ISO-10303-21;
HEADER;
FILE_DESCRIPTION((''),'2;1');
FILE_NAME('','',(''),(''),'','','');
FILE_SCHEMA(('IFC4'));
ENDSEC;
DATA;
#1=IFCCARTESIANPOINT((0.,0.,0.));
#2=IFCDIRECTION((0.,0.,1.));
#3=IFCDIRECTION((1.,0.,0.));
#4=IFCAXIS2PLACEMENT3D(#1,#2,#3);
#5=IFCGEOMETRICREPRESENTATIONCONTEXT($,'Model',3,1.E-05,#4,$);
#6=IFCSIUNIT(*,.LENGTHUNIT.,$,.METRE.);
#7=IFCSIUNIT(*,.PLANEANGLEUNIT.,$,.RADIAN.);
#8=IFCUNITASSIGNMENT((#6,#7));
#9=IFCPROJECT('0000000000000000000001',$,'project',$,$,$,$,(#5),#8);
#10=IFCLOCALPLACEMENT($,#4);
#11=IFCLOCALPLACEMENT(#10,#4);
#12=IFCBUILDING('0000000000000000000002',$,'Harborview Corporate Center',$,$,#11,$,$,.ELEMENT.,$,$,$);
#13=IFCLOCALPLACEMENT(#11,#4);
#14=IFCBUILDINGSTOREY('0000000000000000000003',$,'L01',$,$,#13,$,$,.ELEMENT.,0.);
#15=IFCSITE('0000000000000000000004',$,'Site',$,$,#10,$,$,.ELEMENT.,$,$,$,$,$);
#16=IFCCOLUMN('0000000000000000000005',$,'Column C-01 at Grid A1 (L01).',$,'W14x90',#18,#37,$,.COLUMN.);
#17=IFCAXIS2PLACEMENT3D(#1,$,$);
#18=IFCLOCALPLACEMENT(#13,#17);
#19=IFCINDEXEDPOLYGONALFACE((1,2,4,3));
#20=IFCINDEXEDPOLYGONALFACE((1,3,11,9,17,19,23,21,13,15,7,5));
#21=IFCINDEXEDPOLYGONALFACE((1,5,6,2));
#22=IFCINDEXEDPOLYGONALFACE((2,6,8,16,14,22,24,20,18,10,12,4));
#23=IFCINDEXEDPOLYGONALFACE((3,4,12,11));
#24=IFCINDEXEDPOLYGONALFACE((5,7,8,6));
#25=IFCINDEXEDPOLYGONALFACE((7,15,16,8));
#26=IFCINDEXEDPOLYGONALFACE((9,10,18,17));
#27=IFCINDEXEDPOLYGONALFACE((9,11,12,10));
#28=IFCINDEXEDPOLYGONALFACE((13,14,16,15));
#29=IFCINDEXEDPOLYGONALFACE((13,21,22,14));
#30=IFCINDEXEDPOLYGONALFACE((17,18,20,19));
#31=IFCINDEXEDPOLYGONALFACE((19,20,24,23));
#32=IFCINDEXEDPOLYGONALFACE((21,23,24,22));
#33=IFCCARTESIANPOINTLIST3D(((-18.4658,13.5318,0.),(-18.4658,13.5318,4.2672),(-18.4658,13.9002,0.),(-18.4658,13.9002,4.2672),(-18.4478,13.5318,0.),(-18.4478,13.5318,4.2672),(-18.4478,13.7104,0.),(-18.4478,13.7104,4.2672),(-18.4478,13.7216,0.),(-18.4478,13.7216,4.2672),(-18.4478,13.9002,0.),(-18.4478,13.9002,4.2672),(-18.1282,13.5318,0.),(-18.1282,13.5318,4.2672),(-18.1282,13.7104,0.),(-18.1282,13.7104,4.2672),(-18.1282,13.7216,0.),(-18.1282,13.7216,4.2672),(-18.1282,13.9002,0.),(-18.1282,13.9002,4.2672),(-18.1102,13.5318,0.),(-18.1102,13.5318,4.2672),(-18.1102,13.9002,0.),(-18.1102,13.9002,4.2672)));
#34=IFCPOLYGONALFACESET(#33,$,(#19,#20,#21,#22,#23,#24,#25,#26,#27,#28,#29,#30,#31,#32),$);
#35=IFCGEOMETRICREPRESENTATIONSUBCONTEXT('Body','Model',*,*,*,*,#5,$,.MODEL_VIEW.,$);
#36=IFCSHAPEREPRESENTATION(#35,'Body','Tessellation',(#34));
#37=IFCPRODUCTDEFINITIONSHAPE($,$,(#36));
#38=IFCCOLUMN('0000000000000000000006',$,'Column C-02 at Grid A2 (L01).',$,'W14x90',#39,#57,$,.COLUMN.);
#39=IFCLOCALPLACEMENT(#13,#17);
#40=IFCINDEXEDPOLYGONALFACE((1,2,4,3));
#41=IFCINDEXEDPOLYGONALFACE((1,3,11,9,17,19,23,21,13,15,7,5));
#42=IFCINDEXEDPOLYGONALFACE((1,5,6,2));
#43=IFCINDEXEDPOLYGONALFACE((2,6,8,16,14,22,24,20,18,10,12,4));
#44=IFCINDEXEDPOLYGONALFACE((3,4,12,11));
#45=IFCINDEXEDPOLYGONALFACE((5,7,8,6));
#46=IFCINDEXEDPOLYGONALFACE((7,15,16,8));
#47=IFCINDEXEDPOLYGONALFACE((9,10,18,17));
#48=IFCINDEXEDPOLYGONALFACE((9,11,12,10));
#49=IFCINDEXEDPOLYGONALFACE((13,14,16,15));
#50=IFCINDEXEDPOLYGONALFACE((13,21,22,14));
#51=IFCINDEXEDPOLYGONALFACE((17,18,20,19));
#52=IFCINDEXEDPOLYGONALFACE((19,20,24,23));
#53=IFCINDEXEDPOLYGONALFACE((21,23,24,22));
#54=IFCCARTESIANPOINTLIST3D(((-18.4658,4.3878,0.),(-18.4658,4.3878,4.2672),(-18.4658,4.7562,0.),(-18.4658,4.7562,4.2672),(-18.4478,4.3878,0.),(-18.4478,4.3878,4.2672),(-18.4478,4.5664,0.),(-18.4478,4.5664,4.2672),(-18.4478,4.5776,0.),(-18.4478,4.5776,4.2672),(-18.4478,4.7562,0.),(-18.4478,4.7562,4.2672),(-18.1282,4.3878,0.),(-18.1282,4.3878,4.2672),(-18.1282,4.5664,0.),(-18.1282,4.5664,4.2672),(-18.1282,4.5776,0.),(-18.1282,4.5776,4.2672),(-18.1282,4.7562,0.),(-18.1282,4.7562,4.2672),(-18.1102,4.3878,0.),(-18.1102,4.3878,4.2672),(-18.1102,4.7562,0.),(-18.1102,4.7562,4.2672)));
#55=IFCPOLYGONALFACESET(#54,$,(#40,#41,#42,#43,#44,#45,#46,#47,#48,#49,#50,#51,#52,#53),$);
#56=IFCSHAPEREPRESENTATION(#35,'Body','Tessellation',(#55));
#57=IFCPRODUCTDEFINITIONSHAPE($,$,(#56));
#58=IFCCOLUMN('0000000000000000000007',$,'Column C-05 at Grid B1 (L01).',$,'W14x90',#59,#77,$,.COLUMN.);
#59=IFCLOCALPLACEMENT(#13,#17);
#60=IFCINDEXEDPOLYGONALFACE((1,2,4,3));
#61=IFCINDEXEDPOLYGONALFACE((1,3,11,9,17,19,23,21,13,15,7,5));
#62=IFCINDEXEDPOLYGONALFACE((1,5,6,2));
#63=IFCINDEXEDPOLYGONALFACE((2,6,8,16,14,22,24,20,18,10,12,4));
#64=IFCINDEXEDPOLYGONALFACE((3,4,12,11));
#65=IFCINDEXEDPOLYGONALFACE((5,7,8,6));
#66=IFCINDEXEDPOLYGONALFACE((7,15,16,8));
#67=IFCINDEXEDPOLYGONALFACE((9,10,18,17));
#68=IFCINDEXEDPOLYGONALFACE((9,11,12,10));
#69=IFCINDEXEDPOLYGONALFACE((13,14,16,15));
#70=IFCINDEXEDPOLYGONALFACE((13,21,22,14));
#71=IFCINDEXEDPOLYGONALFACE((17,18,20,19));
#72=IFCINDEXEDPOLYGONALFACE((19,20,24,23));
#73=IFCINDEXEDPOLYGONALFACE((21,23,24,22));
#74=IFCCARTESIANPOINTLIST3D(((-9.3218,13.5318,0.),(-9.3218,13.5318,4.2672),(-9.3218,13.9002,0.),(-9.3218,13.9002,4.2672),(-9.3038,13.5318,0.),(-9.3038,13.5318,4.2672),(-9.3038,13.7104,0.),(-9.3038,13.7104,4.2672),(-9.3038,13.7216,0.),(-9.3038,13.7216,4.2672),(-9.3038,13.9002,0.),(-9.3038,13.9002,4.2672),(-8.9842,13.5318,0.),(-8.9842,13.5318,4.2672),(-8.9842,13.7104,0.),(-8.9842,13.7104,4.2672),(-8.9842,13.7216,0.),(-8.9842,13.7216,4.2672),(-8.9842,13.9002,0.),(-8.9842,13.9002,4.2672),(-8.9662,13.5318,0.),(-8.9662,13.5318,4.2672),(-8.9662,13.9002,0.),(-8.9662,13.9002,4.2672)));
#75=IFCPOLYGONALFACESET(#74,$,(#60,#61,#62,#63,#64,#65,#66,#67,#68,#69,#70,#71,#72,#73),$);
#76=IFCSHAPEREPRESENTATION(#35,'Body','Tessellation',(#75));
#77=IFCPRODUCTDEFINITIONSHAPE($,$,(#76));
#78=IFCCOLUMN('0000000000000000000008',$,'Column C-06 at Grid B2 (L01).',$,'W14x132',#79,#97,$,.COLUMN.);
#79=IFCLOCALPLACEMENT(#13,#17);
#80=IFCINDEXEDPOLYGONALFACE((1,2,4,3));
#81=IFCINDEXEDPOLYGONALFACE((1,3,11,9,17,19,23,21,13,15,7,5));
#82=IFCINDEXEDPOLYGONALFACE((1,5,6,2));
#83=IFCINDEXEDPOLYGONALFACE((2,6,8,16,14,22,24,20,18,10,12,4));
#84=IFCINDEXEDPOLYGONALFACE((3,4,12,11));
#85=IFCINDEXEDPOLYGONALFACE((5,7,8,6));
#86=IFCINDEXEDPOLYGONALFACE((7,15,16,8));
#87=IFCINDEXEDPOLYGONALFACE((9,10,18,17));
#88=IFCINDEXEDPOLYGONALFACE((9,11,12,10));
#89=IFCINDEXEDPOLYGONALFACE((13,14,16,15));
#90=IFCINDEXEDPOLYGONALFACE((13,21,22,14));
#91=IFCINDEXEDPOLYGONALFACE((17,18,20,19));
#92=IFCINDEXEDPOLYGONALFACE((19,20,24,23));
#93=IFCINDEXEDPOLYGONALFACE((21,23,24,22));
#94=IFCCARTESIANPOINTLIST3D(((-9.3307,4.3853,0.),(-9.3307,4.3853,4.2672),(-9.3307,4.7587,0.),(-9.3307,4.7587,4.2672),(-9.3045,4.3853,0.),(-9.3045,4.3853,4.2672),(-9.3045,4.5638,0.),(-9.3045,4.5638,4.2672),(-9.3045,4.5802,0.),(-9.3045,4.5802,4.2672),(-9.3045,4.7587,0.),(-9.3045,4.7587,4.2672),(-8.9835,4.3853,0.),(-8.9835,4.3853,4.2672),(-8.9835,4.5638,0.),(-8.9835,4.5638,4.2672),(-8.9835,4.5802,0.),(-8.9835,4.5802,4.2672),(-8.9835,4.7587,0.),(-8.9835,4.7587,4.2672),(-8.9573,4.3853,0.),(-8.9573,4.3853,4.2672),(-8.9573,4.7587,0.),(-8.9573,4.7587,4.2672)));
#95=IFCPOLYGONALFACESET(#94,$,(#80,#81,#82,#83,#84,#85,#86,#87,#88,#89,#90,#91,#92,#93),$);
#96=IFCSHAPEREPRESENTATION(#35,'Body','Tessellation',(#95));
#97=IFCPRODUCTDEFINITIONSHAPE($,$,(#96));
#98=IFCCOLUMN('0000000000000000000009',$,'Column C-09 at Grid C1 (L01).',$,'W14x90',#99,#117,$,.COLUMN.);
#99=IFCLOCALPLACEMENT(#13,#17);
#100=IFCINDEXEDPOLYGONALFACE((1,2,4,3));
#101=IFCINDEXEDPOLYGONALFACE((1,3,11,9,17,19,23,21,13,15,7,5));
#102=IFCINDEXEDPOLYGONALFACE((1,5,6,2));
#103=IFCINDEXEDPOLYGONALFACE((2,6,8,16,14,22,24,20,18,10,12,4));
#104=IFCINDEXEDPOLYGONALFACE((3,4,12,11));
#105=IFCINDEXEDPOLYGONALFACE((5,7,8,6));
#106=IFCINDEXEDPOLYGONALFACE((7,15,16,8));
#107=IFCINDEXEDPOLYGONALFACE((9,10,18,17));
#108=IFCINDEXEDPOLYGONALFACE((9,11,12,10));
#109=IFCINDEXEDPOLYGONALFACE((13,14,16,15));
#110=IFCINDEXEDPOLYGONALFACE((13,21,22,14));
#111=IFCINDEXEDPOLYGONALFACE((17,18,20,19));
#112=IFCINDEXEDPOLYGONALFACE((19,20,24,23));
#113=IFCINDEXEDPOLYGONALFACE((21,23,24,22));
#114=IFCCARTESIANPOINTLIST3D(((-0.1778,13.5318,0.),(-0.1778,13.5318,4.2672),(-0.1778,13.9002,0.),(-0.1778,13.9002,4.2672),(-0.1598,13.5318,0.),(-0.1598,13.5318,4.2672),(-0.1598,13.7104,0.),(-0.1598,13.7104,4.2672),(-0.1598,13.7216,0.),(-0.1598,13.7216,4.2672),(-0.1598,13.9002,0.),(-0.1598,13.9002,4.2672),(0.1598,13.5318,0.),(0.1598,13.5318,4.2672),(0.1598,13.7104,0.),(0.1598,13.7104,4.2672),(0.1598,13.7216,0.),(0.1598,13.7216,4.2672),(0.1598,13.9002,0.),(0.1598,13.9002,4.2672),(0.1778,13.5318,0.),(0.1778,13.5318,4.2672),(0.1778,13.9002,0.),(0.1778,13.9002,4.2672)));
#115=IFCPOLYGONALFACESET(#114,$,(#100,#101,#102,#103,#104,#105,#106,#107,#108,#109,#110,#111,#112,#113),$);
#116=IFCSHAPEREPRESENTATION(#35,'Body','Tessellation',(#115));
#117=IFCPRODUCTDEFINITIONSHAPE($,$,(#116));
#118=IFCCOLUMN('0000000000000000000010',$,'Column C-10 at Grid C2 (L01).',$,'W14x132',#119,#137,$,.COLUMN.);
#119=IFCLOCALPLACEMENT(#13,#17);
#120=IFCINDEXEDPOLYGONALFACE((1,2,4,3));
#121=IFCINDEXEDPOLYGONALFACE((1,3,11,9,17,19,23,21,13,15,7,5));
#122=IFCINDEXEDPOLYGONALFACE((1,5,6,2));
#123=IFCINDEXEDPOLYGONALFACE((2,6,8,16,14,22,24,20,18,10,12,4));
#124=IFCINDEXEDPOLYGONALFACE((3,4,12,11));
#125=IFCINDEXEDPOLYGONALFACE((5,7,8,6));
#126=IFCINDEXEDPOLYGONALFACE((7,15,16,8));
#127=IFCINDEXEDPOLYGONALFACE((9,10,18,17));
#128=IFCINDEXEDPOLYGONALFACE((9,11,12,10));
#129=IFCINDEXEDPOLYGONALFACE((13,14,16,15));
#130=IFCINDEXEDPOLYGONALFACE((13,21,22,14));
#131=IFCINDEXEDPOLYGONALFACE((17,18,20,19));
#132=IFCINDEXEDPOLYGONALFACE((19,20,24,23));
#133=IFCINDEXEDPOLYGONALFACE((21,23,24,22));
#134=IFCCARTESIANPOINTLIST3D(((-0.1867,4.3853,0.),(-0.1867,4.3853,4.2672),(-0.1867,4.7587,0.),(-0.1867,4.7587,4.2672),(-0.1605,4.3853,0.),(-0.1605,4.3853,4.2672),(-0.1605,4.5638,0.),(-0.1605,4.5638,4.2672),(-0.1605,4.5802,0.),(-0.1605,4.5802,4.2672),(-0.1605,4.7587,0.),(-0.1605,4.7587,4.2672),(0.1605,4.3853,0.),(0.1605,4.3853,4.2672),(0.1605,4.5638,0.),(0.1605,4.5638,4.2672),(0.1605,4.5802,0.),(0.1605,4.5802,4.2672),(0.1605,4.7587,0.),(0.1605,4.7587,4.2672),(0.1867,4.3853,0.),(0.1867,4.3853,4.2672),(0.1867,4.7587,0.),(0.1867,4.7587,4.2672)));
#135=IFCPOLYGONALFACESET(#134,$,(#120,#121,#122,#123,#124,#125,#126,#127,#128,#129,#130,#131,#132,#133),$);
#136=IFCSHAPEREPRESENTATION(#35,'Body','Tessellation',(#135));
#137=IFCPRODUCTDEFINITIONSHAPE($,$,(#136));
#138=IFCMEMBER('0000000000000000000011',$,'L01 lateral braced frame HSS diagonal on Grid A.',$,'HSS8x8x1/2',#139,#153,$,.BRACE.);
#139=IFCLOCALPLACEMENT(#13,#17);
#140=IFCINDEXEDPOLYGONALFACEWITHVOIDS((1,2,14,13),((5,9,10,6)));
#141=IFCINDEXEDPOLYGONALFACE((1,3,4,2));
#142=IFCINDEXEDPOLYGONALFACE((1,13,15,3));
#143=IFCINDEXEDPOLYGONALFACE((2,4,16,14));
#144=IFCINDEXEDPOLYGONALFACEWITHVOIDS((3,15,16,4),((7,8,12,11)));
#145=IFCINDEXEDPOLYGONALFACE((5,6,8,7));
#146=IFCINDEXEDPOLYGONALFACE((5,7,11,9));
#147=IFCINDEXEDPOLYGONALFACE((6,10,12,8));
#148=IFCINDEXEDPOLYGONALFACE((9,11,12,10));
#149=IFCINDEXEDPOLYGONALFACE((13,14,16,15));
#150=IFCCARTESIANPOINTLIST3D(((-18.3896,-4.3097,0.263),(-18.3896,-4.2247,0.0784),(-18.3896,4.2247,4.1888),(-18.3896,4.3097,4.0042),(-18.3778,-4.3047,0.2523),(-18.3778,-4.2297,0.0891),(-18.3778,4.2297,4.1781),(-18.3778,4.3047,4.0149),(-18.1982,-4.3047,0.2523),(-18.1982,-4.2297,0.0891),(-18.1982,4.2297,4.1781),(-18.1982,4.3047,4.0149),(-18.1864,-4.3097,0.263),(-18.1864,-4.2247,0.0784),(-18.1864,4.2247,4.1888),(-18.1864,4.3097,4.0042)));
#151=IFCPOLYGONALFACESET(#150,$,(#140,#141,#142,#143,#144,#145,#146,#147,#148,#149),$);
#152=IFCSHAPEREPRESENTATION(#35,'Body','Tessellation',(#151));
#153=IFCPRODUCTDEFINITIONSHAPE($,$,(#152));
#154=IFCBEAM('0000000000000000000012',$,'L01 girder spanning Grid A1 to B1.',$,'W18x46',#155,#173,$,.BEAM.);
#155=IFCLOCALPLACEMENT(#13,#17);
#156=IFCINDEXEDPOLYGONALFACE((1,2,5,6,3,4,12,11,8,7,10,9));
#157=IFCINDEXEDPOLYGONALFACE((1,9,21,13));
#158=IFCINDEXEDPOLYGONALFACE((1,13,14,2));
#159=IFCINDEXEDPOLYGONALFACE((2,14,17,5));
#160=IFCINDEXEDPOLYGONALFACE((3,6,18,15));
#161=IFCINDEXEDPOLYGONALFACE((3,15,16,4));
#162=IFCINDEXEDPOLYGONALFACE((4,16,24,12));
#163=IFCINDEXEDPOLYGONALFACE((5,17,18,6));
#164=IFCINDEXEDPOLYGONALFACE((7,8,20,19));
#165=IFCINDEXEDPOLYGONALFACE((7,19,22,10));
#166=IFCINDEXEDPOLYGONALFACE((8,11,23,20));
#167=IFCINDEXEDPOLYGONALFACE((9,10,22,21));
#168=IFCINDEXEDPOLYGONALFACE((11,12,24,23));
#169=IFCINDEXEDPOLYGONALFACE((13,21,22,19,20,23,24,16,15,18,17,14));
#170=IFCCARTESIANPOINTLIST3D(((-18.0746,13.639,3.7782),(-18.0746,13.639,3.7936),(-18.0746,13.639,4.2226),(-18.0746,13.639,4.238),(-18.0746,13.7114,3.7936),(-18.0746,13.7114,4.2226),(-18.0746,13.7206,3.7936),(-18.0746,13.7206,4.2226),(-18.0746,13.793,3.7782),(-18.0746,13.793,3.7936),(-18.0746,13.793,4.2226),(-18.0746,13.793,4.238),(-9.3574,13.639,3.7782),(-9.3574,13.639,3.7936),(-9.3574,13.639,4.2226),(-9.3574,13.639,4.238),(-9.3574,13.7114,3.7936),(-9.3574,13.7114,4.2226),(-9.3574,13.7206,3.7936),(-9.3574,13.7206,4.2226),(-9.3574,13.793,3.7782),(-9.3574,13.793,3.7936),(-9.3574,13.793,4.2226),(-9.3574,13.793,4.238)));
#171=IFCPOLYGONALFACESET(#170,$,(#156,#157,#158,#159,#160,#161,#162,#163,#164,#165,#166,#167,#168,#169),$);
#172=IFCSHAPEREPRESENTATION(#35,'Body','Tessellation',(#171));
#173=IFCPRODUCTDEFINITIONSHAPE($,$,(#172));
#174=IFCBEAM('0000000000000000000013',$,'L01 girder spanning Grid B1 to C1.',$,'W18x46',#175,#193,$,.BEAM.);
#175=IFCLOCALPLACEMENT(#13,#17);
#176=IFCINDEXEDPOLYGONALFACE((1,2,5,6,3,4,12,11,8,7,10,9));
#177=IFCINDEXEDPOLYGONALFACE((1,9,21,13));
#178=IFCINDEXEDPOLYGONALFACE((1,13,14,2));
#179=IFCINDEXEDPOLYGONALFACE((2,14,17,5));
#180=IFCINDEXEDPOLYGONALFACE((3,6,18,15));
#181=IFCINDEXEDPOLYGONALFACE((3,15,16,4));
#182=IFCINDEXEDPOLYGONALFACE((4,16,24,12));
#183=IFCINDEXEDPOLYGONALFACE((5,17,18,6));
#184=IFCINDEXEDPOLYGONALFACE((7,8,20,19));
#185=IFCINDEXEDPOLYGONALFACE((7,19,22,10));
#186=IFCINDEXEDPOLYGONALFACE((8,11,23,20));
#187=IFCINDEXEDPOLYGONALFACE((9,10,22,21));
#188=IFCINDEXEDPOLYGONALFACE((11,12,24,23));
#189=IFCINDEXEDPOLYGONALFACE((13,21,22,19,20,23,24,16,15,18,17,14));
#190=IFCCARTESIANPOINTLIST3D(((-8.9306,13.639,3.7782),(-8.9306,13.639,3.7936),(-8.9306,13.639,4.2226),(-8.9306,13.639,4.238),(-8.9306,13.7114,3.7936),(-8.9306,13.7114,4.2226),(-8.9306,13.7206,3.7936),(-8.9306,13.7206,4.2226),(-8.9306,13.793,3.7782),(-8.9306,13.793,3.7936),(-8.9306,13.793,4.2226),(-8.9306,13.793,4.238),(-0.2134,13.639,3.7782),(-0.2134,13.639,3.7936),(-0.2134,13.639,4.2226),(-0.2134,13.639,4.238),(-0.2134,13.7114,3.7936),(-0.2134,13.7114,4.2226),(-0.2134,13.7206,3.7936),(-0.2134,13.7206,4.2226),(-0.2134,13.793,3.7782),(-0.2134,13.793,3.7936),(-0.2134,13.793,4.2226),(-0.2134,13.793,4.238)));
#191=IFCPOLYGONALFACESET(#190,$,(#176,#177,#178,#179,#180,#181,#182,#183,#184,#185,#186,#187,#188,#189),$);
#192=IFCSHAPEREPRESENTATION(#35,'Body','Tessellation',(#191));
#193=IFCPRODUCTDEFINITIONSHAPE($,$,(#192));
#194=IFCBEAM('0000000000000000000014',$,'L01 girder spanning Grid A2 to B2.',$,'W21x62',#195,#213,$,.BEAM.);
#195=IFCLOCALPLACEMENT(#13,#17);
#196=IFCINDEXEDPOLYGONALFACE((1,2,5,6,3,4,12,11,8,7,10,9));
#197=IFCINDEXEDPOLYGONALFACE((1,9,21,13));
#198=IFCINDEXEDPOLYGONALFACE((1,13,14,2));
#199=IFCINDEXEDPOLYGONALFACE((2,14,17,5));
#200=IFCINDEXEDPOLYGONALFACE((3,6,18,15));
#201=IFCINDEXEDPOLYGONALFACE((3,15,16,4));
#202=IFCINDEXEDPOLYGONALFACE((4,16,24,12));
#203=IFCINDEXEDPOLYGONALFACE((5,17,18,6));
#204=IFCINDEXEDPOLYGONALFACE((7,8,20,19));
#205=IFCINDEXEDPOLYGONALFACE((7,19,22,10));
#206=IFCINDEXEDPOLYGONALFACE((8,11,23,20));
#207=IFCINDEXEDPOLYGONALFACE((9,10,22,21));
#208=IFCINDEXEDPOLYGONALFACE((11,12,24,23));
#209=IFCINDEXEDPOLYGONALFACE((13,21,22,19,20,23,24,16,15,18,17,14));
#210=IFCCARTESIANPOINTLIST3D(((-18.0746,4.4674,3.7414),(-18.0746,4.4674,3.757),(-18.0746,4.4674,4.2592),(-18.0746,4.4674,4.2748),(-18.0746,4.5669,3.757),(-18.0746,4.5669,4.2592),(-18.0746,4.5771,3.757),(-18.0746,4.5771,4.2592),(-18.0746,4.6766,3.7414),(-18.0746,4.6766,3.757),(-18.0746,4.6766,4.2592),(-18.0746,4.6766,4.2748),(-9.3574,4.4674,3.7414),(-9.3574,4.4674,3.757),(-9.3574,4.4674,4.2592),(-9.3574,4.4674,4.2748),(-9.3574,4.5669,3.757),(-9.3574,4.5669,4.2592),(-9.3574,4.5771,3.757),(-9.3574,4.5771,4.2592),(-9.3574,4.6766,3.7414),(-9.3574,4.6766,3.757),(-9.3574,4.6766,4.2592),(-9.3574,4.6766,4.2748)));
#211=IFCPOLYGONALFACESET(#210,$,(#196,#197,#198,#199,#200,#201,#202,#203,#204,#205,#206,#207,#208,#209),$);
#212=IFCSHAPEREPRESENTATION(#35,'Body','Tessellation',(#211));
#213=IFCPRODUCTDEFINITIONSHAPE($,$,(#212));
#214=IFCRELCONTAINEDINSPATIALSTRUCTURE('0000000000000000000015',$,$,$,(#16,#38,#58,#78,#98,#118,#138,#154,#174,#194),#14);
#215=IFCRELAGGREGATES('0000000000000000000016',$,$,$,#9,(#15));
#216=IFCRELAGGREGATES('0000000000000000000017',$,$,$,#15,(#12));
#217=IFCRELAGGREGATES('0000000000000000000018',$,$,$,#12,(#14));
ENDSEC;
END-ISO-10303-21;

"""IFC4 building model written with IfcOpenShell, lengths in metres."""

from ifc_helpers import new_model, si_unit, frame, origin_with_axes, place, context, subcontext, project, spatial, hollow_rectangle, i_section, extrude, element, save


model = new_model("IFC4")

# Units and contexts
model_context = context("Model", 3, precision=1e-05, world=origin_with_axes())
body_context = subcontext(model_context, "Body", "Model", "MODEL_VIEW")
ifc_project = project(units=[si_unit("LENGTHUNIT", "METRE"), si_unit("PLANEANGLEUNIT", "RADIAN")], contexts=[model_context])

# Site, building, storey
site_placement = place(None, origin_with_axes())
site = spatial("IfcSite", under=ifc_project, at=site_placement, Name="Site", CompositionType="ELEMENT")
building_placement = place(site_placement, origin_with_axes())
building = spatial("IfcBuilding", under=site, at=building_placement, Name="Harborview Corporate Center", CompositionType="ELEMENT")
storey_placement = place(building_placement, origin_with_axes())
storey = spatial("IfcBuildingStorey", under=building, at=storey_placement, Name="L01", CompositionType="ELEMENT", Elevation=0.0)

# Columns
for number, where, z_axis, x_axis, name in (
    (1, (-18.288, 13.716, 0.0), (0.0, 0.0, 1.0), (0.0, 1.0, 0.0), "Column C-01 at Grid A1 (L01)."),
    (2, (-18.288, 4.572, 0.0), (0.0, 0.0, 1.0), (0.0, 1.0, 0.0), "Column C-02 at Grid A2 (L01)."),
    (3, (-9.144, 13.716, 0.0), (0.0, 0.0, 1.0), (0.0, 1.0, 0.0), "Column C-05 at Grid B1 (L01)."),
):
    element("IfcColumn", number, at=place(storey_placement, frame(where, z_axis=z_axis, x_axis=x_axis)), inside=storey, Name=name, ObjectType="W14x90", PredefinedType="COLUMN", context=body_context, shape_type="SweptSolid", body=[
        extrude(i_section(OverallWidth=0.3683, OverallDepth=0.3556, WebThickness=0.0112, FlangeThickness=0.018), origin_with_axes(), (0.0, 0.0, 1.0), 4.2672),
    ])
column_1_placement = place(storey_placement, frame((-9.144, 4.572, 0.0), z_axis=(0.0, 0.0, 1.0), x_axis=(0.0, 1.0, 0.0)))
element("IfcColumn", 4, at=column_1_placement, inside=storey, Name="Column C-06 at Grid B2 (L01).", ObjectType="W14x132", PredefinedType="COLUMN", context=body_context, shape_type="SweptSolid", body=[
    extrude(i_section(OverallWidth=0.3734, OverallDepth=0.3734, WebThickness=0.0164, FlangeThickness=0.0262), origin_with_axes(), (0.0, 0.0, 1.0), 4.2672),
])
column_2_placement = place(storey_placement, frame((0.0, 13.716, 0.0), z_axis=(0.0, 0.0, 1.0), x_axis=(0.0, 1.0, 0.0)))
element("IfcColumn", 5, at=column_2_placement, inside=storey, Name="Column C-09 at Grid C1 (L01).", ObjectType="W14x90", PredefinedType="COLUMN", context=body_context, shape_type="SweptSolid", body=[
    extrude(i_section(OverallWidth=0.3683, OverallDepth=0.3556, WebThickness=0.0112, FlangeThickness=0.018), origin_with_axes(), (0.0, 0.0, 1.0), 4.2672),
])
column_3_placement = place(storey_placement, frame((0.0, 4.572, 0.0), z_axis=(0.0, 0.0, 1.0), x_axis=(0.0, 1.0, 0.0)))
element("IfcColumn", 6, at=column_3_placement, inside=storey, Name="Column C-10 at Grid C2 (L01).", ObjectType="W14x132", PredefinedType="COLUMN", context=body_context, shape_type="SweptSolid", body=[
    extrude(i_section(OverallWidth=0.3734, OverallDepth=0.3734, WebThickness=0.0164, FlangeThickness=0.0262), origin_with_axes(), (0.0, 0.0, 1.0), 4.2672),
])

# Member
member_placement = place(storey_placement, frame((-18.288, -4.2672, 0.1707), z_axis=(0.0, 0.90849, 0.417906), x_axis=(-1.0, 0.0, 0.0)))
element("IfcMember", 7, at=member_placement, inside=storey, Name="L01 lateral braced frame HSS diagonal on Grid A.", ObjectType="HSS8x8x1/2", PredefinedType="BRACE", context=body_context, shape_type="SweptSolid", body=[
    extrude(hollow_rectangle(XDim=0.2032, YDim=0.2032, WallThickness=0.0118), origin_with_axes(), (0.0, 0.0, 1.0), 9.394),
])

# Beams
beam_1_placement = place(storey_placement, frame((-18.0746, 13.716, 4.0081), z_axis=(1.0, 0.0, 0.0), x_axis=(0.0, 1.0, 0.0)))
element("IfcBeam", 8, at=beam_1_placement, inside=storey, Name="L01 girder spanning Grid A1 to B1.", ObjectType="W18x46", PredefinedType="BEAM", context=body_context, shape_type="SweptSolid", body=[
    extrude(i_section(OverallWidth=0.1539, OverallDepth=0.4597, WebThickness=0.0091, FlangeThickness=0.0154), origin_with_axes(), (0.0, 0.0, 1.0), 8.7173),
])
beam_2_placement = place(storey_placement, frame((-8.9306, 13.716, 4.0081), z_axis=(1.0, 0.0, 0.0), x_axis=(0.0, 1.0, 0.0)))
element("IfcBeam", 9, at=beam_2_placement, inside=storey, Name="L01 girder spanning Grid B1 to C1.", ObjectType="W18x46", PredefinedType="BEAM", context=body_context, shape_type="SweptSolid", body=[
    extrude(i_section(OverallWidth=0.1539, OverallDepth=0.4597, WebThickness=0.0091, FlangeThickness=0.0154), origin_with_axes(), (0.0, 0.0, 1.0), 8.7173),
])
beam_3_placement = place(storey_placement, frame((-18.0746, 4.572, 4.0081), z_axis=(1.0, 0.0, 0.0), x_axis=(0.0, 1.0, 0.0)))
element("IfcBeam", 10, at=beam_3_placement, inside=storey, Name="L01 girder spanning Grid A2 to B2.", ObjectType="W21x62", PredefinedType="BEAM", context=body_context, shape_type="SweptSolid", body=[
    extrude(i_section(OverallWidth=0.2093, OverallDepth=0.5334, WebThickness=0.0102, FlangeThickness=0.0156), origin_with_axes(), (0.0, 0.0, 1.0), 8.7173),
])

save(model, "model.ifc")
